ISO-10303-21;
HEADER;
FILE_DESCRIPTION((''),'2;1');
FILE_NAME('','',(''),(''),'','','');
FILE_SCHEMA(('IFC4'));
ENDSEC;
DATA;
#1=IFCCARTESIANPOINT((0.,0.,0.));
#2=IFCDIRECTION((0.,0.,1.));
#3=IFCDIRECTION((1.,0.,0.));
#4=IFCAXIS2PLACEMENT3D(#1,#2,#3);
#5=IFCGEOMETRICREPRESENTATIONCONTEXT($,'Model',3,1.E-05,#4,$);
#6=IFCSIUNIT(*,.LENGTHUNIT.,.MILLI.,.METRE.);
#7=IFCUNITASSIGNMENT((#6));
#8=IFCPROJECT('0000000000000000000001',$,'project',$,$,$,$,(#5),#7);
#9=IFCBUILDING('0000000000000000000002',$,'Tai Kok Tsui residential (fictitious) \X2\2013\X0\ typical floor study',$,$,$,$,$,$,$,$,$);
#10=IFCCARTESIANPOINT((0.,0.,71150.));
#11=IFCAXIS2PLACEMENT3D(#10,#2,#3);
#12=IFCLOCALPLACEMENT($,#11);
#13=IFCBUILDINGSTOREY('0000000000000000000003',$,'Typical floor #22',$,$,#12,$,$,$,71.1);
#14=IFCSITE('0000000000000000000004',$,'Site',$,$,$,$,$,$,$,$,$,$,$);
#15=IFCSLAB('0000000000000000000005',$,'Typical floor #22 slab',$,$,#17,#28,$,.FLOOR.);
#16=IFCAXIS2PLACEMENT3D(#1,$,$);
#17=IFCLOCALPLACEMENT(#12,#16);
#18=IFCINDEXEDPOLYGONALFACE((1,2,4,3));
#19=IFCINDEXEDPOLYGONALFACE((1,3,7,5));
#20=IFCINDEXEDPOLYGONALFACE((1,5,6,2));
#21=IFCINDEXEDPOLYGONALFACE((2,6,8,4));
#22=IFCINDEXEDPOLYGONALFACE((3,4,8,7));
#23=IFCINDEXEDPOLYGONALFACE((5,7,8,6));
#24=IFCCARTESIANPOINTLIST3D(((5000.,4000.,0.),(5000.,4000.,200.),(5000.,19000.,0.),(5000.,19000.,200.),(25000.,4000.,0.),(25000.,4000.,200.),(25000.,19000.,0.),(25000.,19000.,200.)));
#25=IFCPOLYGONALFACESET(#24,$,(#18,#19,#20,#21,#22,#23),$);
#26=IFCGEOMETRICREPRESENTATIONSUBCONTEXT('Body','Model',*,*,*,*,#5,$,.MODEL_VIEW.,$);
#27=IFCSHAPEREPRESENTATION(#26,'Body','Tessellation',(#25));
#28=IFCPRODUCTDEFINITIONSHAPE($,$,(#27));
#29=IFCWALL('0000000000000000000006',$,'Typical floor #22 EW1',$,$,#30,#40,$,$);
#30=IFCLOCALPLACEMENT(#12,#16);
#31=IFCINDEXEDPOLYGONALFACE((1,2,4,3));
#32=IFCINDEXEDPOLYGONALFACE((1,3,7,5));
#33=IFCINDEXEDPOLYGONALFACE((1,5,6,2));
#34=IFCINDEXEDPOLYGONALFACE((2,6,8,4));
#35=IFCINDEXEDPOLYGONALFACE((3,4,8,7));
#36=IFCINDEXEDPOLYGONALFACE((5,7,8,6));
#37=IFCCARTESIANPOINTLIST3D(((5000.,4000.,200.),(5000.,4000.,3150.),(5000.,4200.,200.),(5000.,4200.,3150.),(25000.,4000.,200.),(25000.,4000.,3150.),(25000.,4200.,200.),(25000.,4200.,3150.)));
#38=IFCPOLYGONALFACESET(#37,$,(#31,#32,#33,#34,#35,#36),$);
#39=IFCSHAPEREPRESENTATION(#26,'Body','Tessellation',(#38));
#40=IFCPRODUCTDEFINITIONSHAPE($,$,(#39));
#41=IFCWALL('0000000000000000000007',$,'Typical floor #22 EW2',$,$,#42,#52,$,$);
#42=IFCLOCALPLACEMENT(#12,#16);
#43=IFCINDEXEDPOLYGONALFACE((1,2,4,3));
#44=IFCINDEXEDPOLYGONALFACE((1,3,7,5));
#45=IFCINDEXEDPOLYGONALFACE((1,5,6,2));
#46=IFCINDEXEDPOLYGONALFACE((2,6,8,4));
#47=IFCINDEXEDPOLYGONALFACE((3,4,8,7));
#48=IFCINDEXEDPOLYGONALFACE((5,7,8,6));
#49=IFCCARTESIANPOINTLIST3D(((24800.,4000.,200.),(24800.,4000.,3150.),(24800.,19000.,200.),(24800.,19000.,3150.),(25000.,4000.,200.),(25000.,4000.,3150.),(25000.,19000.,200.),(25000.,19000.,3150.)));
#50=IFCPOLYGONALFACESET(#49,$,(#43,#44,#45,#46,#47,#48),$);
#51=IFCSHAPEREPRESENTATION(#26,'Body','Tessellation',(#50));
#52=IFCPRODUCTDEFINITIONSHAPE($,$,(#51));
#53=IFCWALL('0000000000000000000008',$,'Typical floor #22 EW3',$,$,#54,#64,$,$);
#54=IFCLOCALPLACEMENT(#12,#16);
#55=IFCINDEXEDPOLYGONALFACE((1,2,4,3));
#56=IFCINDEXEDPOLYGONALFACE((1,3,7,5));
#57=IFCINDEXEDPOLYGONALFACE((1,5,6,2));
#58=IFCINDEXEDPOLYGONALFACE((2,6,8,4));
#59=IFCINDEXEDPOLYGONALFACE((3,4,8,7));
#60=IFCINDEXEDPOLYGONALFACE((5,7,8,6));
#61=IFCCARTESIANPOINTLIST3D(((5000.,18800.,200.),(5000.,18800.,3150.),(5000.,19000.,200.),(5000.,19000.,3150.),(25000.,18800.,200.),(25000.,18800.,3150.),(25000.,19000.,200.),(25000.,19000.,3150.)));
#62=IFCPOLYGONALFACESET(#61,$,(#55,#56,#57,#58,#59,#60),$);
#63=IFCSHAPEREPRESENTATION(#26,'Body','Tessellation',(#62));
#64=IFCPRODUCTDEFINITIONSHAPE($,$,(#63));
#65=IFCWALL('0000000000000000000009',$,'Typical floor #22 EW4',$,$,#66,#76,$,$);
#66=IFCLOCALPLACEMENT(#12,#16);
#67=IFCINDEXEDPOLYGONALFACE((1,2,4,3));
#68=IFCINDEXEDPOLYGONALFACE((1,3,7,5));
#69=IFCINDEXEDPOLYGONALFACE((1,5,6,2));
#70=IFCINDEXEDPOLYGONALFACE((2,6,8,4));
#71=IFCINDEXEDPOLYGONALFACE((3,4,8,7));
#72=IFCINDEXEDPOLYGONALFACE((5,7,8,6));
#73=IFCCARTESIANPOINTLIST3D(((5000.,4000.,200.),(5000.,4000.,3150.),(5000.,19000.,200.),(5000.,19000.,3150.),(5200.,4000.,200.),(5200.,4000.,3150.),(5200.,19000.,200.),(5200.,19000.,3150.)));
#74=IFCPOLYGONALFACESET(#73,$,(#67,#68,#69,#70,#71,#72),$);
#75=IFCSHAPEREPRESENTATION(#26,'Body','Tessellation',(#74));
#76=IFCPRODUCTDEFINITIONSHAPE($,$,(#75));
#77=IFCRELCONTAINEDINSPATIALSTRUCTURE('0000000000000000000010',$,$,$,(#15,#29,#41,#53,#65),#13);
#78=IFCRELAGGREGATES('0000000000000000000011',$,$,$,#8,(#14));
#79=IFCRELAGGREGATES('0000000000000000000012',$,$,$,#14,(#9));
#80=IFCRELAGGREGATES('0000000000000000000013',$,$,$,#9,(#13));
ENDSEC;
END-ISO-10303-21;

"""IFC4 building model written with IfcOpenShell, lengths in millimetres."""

from ifc_helpers import new_model, si_unit, frame, origin_with_axes, place, context, subcontext, project, spatial, indexed_curve, outline, extrude, element, save


model = new_model("IFC4")

# Units and contexts
model_context = context("Model", 3, precision=1e-05, world=origin_with_axes())
body_context = subcontext(model_context, "Body", "Model", "MODEL_VIEW")
ifc_project = project(units=[si_unit("LENGTHUNIT", "METRE", prefix="MILLI")], contexts=[model_context])

# Site, building, storey
site = spatial("IfcSite", under=ifc_project, Name="Site")
building = spatial("IfcBuilding", under=site, Name="Tai Kok Tsui residential (fictitious) – typical floor study")
storey_placement = place(None, frame((0.0, 0.0, 71150.0), z_axis=(0.0, 0.0, 1.0), x_axis=(1.0, 0.0, 0.0)))
storey = spatial("IfcBuildingStorey", under=building, at=storey_placement, Name="Typical floor #22", Elevation=71.1)

# Slab
slab_placement = place(storey_placement, origin_with_axes())
element("IfcSlab", 1, at=slab_placement, inside=storey, Name="Typical floor #22 slab", PredefinedType="FLOOR", context=body_context, shape_type="SweptSolid", body=[
    extrude(outline(indexed_curve([(5000.0, 4000.0), (25000.0, 4000.0), (25000.0, 19000.0), (5000.0, 19000.0)])), None, (0.0, 0.0, 1.0), 200.0),
])

# Walls
wall_1_placement = place(storey_placement, frame((5000.0, 4000.0, 200.0), z_axis=(0.0, 0.0, 1.0), x_axis=(1.0, 0.0, 0.0)))
element("IfcWall", 2, at=wall_1_placement, inside=storey, Name="Typical floor #22 EW1", context=body_context, shape_type="SweptSolid", body=[
    extrude(outline(indexed_curve([(0.0, 0.0), (0.0, 200.0), (20000.0, 200.0), (20000.0, 0.0), (0.0, 0.0)], self_intersect=False)), origin_with_axes(), (0.0, 0.0, 1.0), 2950.0),
])
wall_2_placement = place(storey_placement, frame((25000.0, 4000.0, 200.0), z_axis=(0.0, 0.0, 1.0), x_axis=(0.0, 1.0, 0.0)))
element("IfcWall", 3, at=wall_2_placement, inside=storey, Name="Typical floor #22 EW2", context=body_context, shape_type="SweptSolid", body=[
    extrude(outline(indexed_curve([(0.0, 0.0), (0.0, 200.0), (15000.0, 200.0), (15000.0, 0.0), (0.0, 0.0)], self_intersect=False)), origin_with_axes(), (0.0, 0.0, 1.0), 2950.0),
])
wall_3_placement = place(storey_placement, frame((25000.0, 19000.0, 200.0), z_axis=(0.0, 0.0, 1.0), x_axis=(-1.0, 0.0, 0.0)))
element("IfcWall", 4, at=wall_3_placement, inside=storey, Name="Typical floor #22 EW3", context=body_context, shape_type="SweptSolid", body=[
    extrude(outline(indexed_curve([(0.0, 0.0), (0.0, 200.0), (20000.0, 200.0), (20000.0, 0.0), (0.0, 0.0)], self_intersect=False)), origin_with_axes(), (0.0, 0.0, 1.0), 2950.0),
])
wall_4_placement = place(storey_placement, frame((5000.0, 19000.0, 200.0), z_axis=(0.0, 0.0, 1.0), x_axis=(0.0, -1.0, 0.0)))
element("IfcWall", 5, at=wall_4_placement, inside=storey, Name="Typical floor #22 EW4", context=body_context, shape_type="SweptSolid", body=[
    extrude(outline(indexed_curve([(0.0, 0.0), (0.0, 200.0), (15000.0, 200.0), (15000.0, 0.0), (0.0, 0.0)], self_intersect=False)), origin_with_axes(), (0.0, 0.0, 1.0), 2950.0),
])

save(model, "model.ifc")
